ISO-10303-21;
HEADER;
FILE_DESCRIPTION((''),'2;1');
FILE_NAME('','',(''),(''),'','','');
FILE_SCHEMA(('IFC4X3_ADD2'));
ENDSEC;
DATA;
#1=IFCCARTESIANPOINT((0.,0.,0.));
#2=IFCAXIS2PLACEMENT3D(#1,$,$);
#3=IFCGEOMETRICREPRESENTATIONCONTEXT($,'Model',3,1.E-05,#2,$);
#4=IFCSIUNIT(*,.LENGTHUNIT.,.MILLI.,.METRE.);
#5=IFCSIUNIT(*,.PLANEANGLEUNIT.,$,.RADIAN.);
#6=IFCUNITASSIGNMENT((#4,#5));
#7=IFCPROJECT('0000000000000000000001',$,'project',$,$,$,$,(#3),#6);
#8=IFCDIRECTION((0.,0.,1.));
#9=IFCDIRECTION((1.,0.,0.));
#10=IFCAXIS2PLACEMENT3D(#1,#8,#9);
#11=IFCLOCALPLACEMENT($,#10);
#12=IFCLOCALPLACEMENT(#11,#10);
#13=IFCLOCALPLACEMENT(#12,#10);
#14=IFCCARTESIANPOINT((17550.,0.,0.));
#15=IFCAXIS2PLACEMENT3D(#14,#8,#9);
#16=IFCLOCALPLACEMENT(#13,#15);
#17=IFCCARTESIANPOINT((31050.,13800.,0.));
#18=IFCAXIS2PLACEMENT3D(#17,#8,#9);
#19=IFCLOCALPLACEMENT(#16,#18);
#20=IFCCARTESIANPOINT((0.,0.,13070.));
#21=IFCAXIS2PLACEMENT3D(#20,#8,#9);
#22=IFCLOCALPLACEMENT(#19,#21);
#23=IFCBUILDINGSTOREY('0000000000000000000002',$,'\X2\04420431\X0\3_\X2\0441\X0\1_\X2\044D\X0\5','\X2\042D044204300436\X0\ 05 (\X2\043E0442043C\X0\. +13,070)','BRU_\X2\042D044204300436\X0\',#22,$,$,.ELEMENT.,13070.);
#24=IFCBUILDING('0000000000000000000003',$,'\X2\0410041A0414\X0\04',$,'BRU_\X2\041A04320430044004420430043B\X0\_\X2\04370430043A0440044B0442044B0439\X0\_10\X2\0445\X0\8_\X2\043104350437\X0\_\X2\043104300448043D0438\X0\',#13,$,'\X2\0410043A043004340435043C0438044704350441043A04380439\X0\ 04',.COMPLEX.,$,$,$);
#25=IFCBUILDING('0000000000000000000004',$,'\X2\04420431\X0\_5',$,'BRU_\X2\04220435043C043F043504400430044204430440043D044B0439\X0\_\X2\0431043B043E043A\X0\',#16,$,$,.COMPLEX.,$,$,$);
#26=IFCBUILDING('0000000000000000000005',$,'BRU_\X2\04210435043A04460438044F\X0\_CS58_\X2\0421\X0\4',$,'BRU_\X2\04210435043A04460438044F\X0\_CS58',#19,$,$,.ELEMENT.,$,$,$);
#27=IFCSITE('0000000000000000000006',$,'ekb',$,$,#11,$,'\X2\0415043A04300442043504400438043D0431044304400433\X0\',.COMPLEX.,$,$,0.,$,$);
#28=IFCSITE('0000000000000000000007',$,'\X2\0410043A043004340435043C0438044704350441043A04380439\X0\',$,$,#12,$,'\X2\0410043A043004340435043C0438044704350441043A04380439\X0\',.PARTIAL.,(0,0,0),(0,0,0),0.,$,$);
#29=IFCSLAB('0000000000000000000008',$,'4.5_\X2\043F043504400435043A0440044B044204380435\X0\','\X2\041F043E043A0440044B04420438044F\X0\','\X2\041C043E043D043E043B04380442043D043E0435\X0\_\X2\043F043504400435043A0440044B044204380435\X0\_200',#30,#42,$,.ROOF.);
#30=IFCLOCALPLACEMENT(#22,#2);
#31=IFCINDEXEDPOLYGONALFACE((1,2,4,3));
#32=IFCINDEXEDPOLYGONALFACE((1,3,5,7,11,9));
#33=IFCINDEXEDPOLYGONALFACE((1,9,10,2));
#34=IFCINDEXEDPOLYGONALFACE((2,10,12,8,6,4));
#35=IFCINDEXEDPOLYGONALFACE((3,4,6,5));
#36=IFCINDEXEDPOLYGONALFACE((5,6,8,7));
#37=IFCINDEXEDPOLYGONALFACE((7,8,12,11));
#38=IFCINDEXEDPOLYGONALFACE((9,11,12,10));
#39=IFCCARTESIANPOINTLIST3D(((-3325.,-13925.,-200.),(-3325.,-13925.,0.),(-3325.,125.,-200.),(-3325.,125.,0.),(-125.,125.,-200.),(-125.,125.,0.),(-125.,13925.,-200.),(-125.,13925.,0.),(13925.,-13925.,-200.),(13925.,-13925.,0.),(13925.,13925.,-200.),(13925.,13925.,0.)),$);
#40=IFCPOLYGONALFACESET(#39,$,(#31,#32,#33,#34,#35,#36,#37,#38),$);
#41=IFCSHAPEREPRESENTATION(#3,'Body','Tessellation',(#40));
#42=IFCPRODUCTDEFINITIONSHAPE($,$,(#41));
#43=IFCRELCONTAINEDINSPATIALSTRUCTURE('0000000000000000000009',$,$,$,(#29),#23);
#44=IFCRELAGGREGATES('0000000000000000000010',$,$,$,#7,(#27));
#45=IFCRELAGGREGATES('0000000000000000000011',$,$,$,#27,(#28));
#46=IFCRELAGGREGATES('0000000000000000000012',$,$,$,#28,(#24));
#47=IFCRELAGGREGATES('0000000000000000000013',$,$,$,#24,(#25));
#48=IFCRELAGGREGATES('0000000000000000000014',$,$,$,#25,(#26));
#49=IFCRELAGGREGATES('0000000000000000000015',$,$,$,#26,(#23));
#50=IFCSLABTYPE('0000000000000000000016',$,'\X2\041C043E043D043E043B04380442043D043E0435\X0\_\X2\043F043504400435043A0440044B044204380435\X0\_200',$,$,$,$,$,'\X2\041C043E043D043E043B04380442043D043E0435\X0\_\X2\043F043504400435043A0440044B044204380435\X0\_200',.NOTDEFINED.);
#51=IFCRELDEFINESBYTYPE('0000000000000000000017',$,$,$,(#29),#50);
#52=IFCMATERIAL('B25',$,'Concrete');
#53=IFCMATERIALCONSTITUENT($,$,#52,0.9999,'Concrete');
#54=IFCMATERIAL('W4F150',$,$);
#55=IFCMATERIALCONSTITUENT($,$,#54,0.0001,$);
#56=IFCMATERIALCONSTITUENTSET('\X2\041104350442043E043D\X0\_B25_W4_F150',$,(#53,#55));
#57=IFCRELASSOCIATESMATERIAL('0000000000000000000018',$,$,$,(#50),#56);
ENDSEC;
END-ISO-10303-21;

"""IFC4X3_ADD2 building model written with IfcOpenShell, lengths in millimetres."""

from ifc_helpers import new_model, si_unit, frame, origin, origin_with_axes, place, context, project, spatial, polyline, outline, extrude, material, constituent, constituent_set, type_object, element, save


model = new_model("IFC4X3_ADD2")

# Units and contexts
model_context = context("Model", 3, precision=1e-05, world=origin())
ifc_project = project(units=[si_unit("LENGTHUNIT", "METRE", prefix="MILLI"), si_unit("PLANEANGLEUNIT", "RADIAN")], contexts=[model_context])

# Sites, buildings, storey
site_1_placement = place(None, origin_with_axes())
site_1 = spatial("IfcSite", under=ifc_project, at=site_1_placement, Name="ekb", LongName="Екатеринбург", CompositionType="COMPLEX", RefElevation=0.0)
site_2_placement = place(site_1_placement, origin_with_axes())
site_2 = spatial("IfcSite", under=site_1, at=site_2_placement, Name="Академический", LongName="Академический", CompositionType="PARTIAL", RefLatitude=(0, 0, 0), RefLongitude=(0, 0, 0), RefElevation=0.0)
building_1_placement = place(site_2_placement, origin_with_axes())
building_1 = spatial("IfcBuilding", under=site_2, at=building_1_placement, Name="АКД04", ObjectType="BRU_Квартал_закрытый_10х8_без_башни", LongName="Академический 04", CompositionType="COMPLEX")
building_2_placement = place(building_1_placement, frame((17550.0, 0.0, 0.0), z_axis=(0.0, 0.0, 1.0), x_axis=(1.0, 0.0, 0.0)))
building_2 = spatial("IfcBuilding", under=building_1, at=building_2_placement, Name="тб_5", ObjectType="BRU_Температурный_блок", CompositionType="COMPLEX")
building_3_placement = place(building_2_placement, frame((31050.0, 13800.0, 0.0), z_axis=(0.0, 0.0, 1.0), x_axis=(1.0, 0.0, 0.0)))
building_3 = spatial("IfcBuilding", under=building_2, at=building_3_placement, Name="BRU_Секция_CS58_С4", ObjectType="BRU_Секция_CS58", CompositionType="ELEMENT")
storey_placement = place(building_3_placement, frame((0.0, 0.0, 13070.0), z_axis=(0.0, 0.0, 1.0), x_axis=(1.0, 0.0, 0.0)))
storey = spatial("IfcBuildingStorey", under=building_3, at=storey_placement, Name="тб3_с1_э5", Description="Этаж 05 (отм. +13,070)", ObjectType="BRU_Этаж", CompositionType="ELEMENT", Elevation=13070.0)

# Shared definitions
ifc_material_1 = material(Name="B25", Category="Concrete")
ifc_material_2 = material(Name="W4F150")

# Slab
ifc_constituent_1 = constituent(ifc_material_1, Category="Concrete", fraction=0.9999)
ifc_constituent_2 = constituent(ifc_material_2, fraction=0.0001)
ifc_constituent_set_1 = constituent_set(constituents=[ifc_constituent_1, ifc_constituent_2], Name="Бетон_B25_W4_F150")
slab_type = type_object("IfcSlabType", Name="Монолитное_перекрытие_200", ElementType="Монолитное_перекрытие_200", PredefinedType="NOTDEFINED", material=ifc_constituent_set_1)
slab_placement = place(storey_placement, frame((0.0, 0.0, -200.0), z_axis=(0.0, 0.0, 1.0), x_axis=(1.0, 0.0, 0.0)))
element("IfcSlab", 1, at=slab_placement, inside=storey, type_object=slab_type, Name="4.5_перекрытие", Description="Покрытия", ObjectType="Монолитное_перекрытие_200", PredefinedType="ROOF", context=model_context, shape_type="SweptSolid", body=[
    extrude(outline(polyline([(13925.0, -13925.0), (13925.0, 13925.0), (-125.0, 13925.0), (-125.0, 125.0), (-3325.0, 125.0), (-3325.0, -13925.0), (13925.0, -13925.0)])), origin_with_axes(), (0.0, 0.0, 1.0), 200.0),
])

save(model, "model.ifc")
